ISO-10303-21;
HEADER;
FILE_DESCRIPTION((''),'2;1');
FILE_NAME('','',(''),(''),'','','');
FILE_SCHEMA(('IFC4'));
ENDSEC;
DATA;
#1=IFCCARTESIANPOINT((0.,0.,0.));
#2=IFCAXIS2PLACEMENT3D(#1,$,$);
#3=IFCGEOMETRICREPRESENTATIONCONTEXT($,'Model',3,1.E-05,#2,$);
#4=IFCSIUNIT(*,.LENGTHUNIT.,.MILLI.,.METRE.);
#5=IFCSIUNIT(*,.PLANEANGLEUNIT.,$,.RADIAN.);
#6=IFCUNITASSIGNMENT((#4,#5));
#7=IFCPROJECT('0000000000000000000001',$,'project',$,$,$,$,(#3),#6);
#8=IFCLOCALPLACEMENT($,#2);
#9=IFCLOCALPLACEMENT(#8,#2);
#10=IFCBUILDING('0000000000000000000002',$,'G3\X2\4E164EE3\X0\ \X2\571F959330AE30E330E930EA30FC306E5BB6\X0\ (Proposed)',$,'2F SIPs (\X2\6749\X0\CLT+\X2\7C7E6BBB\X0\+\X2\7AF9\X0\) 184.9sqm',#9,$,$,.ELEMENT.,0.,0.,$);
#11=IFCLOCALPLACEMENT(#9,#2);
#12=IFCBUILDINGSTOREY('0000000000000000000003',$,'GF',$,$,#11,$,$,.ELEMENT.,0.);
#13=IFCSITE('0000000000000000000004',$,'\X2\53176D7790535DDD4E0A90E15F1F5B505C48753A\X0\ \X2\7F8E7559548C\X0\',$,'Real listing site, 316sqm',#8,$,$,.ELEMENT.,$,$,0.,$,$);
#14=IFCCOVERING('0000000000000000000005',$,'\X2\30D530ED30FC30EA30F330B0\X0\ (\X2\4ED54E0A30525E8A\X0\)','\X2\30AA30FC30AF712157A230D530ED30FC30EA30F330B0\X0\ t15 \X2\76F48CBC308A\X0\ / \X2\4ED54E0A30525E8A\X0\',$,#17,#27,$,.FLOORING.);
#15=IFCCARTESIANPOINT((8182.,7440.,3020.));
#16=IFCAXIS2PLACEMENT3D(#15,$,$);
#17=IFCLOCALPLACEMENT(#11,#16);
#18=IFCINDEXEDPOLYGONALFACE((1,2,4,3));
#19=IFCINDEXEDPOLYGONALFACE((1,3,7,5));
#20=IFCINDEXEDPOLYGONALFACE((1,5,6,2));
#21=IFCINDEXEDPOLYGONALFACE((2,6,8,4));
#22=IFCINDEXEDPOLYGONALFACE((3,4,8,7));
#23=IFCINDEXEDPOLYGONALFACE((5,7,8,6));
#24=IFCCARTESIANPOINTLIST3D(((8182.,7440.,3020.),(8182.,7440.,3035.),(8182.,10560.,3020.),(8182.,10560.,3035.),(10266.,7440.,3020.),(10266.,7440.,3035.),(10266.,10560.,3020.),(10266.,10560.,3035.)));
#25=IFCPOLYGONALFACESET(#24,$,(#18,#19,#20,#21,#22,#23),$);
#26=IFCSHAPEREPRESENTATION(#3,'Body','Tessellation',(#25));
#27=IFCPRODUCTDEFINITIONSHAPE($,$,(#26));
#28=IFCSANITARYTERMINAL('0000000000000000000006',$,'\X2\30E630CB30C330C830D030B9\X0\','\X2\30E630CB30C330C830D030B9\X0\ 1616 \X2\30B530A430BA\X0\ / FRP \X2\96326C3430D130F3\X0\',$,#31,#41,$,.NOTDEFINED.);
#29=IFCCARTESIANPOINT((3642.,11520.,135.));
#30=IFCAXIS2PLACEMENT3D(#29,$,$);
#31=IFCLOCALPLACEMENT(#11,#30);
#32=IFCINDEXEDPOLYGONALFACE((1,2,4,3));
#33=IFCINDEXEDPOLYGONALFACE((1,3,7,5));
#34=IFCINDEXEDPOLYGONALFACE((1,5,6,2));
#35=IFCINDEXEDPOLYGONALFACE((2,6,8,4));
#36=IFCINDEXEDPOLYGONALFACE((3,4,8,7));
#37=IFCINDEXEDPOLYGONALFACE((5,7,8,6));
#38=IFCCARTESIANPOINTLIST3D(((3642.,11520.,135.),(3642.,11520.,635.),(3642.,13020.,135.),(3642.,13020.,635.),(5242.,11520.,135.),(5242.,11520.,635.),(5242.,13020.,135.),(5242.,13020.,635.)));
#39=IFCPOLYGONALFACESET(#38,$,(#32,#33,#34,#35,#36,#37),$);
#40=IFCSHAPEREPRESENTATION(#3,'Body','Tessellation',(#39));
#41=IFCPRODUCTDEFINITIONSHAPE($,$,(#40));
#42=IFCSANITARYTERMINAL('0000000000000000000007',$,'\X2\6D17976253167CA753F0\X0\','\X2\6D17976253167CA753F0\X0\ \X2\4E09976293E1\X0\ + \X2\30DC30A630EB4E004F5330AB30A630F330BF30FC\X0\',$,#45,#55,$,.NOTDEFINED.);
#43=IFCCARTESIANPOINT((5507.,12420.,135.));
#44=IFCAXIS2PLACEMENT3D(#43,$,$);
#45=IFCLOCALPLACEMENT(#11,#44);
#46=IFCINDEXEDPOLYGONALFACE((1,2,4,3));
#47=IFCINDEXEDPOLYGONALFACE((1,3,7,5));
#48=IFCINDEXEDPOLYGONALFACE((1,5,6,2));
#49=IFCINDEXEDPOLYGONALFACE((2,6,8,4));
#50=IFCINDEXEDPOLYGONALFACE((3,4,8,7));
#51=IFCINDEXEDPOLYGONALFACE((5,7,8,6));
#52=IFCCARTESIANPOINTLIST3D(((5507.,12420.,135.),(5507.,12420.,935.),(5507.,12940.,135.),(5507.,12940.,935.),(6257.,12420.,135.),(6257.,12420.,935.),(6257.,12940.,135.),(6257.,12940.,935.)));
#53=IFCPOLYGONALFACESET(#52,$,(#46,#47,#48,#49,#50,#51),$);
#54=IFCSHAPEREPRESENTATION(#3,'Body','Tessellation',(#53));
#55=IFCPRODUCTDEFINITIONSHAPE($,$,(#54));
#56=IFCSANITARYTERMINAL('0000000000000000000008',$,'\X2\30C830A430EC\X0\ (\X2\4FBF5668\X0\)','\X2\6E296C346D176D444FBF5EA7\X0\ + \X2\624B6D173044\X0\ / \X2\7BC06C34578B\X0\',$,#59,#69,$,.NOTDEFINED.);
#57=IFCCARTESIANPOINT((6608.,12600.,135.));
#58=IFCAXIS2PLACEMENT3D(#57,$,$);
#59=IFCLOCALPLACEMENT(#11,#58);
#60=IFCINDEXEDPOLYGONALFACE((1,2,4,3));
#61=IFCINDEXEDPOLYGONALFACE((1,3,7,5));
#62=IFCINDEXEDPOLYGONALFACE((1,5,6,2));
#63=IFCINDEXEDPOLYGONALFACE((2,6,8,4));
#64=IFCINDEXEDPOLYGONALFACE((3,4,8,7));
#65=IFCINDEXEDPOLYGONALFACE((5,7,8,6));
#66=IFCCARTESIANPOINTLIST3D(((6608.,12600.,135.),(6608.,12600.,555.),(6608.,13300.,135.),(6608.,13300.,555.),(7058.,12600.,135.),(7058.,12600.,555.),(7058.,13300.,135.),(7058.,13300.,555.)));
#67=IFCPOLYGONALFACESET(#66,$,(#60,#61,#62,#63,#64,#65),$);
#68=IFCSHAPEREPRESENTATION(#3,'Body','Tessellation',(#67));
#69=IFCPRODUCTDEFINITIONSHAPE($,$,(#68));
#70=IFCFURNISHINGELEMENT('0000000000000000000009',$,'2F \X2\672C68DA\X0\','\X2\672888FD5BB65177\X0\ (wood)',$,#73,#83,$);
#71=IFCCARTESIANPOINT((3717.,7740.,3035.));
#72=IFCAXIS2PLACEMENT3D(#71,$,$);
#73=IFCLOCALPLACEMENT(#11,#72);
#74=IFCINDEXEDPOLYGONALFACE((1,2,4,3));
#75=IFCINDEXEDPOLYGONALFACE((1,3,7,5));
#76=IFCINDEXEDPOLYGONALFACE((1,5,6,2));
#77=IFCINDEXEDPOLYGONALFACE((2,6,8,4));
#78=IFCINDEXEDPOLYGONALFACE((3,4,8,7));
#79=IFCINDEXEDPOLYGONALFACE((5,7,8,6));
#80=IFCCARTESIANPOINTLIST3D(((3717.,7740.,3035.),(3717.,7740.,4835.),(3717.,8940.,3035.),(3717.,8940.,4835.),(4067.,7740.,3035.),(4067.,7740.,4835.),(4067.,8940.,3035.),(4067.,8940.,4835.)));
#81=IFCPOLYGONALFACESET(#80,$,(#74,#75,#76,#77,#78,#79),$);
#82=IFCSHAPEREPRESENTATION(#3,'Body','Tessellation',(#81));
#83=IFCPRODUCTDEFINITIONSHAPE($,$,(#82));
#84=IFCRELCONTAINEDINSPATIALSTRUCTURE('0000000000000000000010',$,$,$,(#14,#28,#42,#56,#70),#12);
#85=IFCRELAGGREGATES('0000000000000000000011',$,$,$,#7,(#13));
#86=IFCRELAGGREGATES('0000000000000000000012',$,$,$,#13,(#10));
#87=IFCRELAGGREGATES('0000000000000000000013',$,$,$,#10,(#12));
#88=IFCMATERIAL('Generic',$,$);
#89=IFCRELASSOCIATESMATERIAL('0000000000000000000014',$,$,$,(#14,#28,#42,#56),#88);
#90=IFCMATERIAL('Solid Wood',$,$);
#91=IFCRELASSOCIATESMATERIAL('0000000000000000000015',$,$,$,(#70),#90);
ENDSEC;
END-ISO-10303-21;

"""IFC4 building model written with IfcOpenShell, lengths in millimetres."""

from ifc_helpers import new_model, si_unit, frame, frame_2d, origin, place, context, project, spatial, rectangle, extrude, material, element, save


model = new_model("IFC4")

# Units and contexts
model_context = context("Model", 3, precision=1e-05, world=origin())
ifc_project = project(units=[si_unit("LENGTHUNIT", "METRE", prefix="MILLI"), si_unit("PLANEANGLEUNIT", "RADIAN")], contexts=[model_context])

# Site, building, storey
site_placement = place(None, origin())
site = spatial("IfcSite", under=ifc_project, at=site_placement, Name="北海道川上郡弟子屈町 美留和", ObjectType="Real listing site, 316sqm", CompositionType="ELEMENT", RefElevation=0.0)
building_placement = place(site_placement, origin())
building = spatial("IfcBuilding", under=site, at=building_placement, Name="G3世代 土間ギャラリーの家 (Proposed)", ObjectType="2F SIPs (杉CLT+籾殻+竹) 184.9sqm", CompositionType="ELEMENT", ElevationOfRefHeight=0.0, ElevationOfTerrain=0.0)
storey_placement = place(building_placement, origin())
storey = spatial("IfcBuildingStorey", under=building, at=storey_placement, Name="GF", CompositionType="ELEMENT", Elevation=0.0)

# Shared definitions
ifc_material_1 = material(Name="Solid Wood")
ifc_material_2 = material(Name="Generic")

# Covering
covering_1_placement = place(storey_placement, frame((8182.0, 7440.0, 3020.0)))
element("IfcCovering", 1, at=covering_1_placement, inside=storey, material=ifc_material_2, Name="フローリング (仕上げ床)", Description="オーク無垢フローリング t15 直貼り / 仕上げ床", PredefinedType="FLOORING", context=model_context, shape_type="SweptSolid", body=[
    extrude(rectangle(XDim=2084.0, YDim=3120.0, at=frame_2d((1042.0, 1560.0))), frame((8182.0, 7440.0, 3020.0)), (0.0, 0.0, 1.0), 15.0),
])

# Sanitary terminals
sanitary_terminal_1_placement = place(storey_placement, frame((3642.0, 11520.0, 135.0)))
element("IfcSanitaryTerminal", 2, at=sanitary_terminal_1_placement, inside=storey, material=ifc_material_2, Name="ユニットバス", Description="ユニットバス 1616 サイズ / FRP 防水パン", PredefinedType="NOTDEFINED", context=model_context, shape_type="SweptSolid", body=[
    extrude(rectangle(XDim=1600.0, YDim=1500.0, at=frame_2d((800.0, 750.0))), frame((3642.0, 11520.0, 135.0)), (0.0, 0.0, 1.0), 500.0),
])
sanitary_terminal_2_placement = place(storey_placement, frame((5507.0, 12420.0, 135.0)))
element("IfcSanitaryTerminal", 3, at=sanitary_terminal_2_placement, inside=storey, material=ifc_material_2, Name="洗面化粧台", Description="洗面化粧台 三面鏡 + ボウル一体カウンター", PredefinedType="NOTDEFINED", context=model_context, shape_type="SweptSolid", body=[
    extrude(rectangle(XDim=750.0, YDim=520.0, at=frame_2d((375.0, 260.0))), frame((5507.0, 12420.0, 135.0)), (0.0, 0.0, 1.0), 800.0),
])
sanitary_terminal_3_placement = place(storey_placement, frame((6608.0, 12600.0, 135.0)))
element("IfcSanitaryTerminal", 4, at=sanitary_terminal_3_placement, inside=storey, material=ifc_material_2, Name="トイレ (便器)", Description="温水洗浄便座 + 手洗い / 節水型", PredefinedType="NOTDEFINED", context=model_context, shape_type="SweptSolid", body=[
    extrude(rectangle(XDim=450.0, YDim=700.0, at=frame_2d((225.0, 350.0))), frame((6608.0, 12600.0, 135.0)), (0.0, 0.0, 1.0), 420.0),
])

# Furnishing element
furnishing_placement = place(storey_placement, frame((3717.0, 7740.0, 3035.0)))
element("IfcFurnishingElement", 5, at=furnishing_placement, inside=storey, material=ifc_material_1, Name="2F 本棚", Description="木製家具 (wood)", context=model_context, shape_type="SweptSolid", body=[
    extrude(rectangle(XDim=350.0, YDim=1200.0, at=frame_2d((175.0, 600.0))), frame((3717.0, 7740.0, 3035.0)), (0.0, 0.0, 1.0), 1800.0),
])

save(model, "model.ifc")
